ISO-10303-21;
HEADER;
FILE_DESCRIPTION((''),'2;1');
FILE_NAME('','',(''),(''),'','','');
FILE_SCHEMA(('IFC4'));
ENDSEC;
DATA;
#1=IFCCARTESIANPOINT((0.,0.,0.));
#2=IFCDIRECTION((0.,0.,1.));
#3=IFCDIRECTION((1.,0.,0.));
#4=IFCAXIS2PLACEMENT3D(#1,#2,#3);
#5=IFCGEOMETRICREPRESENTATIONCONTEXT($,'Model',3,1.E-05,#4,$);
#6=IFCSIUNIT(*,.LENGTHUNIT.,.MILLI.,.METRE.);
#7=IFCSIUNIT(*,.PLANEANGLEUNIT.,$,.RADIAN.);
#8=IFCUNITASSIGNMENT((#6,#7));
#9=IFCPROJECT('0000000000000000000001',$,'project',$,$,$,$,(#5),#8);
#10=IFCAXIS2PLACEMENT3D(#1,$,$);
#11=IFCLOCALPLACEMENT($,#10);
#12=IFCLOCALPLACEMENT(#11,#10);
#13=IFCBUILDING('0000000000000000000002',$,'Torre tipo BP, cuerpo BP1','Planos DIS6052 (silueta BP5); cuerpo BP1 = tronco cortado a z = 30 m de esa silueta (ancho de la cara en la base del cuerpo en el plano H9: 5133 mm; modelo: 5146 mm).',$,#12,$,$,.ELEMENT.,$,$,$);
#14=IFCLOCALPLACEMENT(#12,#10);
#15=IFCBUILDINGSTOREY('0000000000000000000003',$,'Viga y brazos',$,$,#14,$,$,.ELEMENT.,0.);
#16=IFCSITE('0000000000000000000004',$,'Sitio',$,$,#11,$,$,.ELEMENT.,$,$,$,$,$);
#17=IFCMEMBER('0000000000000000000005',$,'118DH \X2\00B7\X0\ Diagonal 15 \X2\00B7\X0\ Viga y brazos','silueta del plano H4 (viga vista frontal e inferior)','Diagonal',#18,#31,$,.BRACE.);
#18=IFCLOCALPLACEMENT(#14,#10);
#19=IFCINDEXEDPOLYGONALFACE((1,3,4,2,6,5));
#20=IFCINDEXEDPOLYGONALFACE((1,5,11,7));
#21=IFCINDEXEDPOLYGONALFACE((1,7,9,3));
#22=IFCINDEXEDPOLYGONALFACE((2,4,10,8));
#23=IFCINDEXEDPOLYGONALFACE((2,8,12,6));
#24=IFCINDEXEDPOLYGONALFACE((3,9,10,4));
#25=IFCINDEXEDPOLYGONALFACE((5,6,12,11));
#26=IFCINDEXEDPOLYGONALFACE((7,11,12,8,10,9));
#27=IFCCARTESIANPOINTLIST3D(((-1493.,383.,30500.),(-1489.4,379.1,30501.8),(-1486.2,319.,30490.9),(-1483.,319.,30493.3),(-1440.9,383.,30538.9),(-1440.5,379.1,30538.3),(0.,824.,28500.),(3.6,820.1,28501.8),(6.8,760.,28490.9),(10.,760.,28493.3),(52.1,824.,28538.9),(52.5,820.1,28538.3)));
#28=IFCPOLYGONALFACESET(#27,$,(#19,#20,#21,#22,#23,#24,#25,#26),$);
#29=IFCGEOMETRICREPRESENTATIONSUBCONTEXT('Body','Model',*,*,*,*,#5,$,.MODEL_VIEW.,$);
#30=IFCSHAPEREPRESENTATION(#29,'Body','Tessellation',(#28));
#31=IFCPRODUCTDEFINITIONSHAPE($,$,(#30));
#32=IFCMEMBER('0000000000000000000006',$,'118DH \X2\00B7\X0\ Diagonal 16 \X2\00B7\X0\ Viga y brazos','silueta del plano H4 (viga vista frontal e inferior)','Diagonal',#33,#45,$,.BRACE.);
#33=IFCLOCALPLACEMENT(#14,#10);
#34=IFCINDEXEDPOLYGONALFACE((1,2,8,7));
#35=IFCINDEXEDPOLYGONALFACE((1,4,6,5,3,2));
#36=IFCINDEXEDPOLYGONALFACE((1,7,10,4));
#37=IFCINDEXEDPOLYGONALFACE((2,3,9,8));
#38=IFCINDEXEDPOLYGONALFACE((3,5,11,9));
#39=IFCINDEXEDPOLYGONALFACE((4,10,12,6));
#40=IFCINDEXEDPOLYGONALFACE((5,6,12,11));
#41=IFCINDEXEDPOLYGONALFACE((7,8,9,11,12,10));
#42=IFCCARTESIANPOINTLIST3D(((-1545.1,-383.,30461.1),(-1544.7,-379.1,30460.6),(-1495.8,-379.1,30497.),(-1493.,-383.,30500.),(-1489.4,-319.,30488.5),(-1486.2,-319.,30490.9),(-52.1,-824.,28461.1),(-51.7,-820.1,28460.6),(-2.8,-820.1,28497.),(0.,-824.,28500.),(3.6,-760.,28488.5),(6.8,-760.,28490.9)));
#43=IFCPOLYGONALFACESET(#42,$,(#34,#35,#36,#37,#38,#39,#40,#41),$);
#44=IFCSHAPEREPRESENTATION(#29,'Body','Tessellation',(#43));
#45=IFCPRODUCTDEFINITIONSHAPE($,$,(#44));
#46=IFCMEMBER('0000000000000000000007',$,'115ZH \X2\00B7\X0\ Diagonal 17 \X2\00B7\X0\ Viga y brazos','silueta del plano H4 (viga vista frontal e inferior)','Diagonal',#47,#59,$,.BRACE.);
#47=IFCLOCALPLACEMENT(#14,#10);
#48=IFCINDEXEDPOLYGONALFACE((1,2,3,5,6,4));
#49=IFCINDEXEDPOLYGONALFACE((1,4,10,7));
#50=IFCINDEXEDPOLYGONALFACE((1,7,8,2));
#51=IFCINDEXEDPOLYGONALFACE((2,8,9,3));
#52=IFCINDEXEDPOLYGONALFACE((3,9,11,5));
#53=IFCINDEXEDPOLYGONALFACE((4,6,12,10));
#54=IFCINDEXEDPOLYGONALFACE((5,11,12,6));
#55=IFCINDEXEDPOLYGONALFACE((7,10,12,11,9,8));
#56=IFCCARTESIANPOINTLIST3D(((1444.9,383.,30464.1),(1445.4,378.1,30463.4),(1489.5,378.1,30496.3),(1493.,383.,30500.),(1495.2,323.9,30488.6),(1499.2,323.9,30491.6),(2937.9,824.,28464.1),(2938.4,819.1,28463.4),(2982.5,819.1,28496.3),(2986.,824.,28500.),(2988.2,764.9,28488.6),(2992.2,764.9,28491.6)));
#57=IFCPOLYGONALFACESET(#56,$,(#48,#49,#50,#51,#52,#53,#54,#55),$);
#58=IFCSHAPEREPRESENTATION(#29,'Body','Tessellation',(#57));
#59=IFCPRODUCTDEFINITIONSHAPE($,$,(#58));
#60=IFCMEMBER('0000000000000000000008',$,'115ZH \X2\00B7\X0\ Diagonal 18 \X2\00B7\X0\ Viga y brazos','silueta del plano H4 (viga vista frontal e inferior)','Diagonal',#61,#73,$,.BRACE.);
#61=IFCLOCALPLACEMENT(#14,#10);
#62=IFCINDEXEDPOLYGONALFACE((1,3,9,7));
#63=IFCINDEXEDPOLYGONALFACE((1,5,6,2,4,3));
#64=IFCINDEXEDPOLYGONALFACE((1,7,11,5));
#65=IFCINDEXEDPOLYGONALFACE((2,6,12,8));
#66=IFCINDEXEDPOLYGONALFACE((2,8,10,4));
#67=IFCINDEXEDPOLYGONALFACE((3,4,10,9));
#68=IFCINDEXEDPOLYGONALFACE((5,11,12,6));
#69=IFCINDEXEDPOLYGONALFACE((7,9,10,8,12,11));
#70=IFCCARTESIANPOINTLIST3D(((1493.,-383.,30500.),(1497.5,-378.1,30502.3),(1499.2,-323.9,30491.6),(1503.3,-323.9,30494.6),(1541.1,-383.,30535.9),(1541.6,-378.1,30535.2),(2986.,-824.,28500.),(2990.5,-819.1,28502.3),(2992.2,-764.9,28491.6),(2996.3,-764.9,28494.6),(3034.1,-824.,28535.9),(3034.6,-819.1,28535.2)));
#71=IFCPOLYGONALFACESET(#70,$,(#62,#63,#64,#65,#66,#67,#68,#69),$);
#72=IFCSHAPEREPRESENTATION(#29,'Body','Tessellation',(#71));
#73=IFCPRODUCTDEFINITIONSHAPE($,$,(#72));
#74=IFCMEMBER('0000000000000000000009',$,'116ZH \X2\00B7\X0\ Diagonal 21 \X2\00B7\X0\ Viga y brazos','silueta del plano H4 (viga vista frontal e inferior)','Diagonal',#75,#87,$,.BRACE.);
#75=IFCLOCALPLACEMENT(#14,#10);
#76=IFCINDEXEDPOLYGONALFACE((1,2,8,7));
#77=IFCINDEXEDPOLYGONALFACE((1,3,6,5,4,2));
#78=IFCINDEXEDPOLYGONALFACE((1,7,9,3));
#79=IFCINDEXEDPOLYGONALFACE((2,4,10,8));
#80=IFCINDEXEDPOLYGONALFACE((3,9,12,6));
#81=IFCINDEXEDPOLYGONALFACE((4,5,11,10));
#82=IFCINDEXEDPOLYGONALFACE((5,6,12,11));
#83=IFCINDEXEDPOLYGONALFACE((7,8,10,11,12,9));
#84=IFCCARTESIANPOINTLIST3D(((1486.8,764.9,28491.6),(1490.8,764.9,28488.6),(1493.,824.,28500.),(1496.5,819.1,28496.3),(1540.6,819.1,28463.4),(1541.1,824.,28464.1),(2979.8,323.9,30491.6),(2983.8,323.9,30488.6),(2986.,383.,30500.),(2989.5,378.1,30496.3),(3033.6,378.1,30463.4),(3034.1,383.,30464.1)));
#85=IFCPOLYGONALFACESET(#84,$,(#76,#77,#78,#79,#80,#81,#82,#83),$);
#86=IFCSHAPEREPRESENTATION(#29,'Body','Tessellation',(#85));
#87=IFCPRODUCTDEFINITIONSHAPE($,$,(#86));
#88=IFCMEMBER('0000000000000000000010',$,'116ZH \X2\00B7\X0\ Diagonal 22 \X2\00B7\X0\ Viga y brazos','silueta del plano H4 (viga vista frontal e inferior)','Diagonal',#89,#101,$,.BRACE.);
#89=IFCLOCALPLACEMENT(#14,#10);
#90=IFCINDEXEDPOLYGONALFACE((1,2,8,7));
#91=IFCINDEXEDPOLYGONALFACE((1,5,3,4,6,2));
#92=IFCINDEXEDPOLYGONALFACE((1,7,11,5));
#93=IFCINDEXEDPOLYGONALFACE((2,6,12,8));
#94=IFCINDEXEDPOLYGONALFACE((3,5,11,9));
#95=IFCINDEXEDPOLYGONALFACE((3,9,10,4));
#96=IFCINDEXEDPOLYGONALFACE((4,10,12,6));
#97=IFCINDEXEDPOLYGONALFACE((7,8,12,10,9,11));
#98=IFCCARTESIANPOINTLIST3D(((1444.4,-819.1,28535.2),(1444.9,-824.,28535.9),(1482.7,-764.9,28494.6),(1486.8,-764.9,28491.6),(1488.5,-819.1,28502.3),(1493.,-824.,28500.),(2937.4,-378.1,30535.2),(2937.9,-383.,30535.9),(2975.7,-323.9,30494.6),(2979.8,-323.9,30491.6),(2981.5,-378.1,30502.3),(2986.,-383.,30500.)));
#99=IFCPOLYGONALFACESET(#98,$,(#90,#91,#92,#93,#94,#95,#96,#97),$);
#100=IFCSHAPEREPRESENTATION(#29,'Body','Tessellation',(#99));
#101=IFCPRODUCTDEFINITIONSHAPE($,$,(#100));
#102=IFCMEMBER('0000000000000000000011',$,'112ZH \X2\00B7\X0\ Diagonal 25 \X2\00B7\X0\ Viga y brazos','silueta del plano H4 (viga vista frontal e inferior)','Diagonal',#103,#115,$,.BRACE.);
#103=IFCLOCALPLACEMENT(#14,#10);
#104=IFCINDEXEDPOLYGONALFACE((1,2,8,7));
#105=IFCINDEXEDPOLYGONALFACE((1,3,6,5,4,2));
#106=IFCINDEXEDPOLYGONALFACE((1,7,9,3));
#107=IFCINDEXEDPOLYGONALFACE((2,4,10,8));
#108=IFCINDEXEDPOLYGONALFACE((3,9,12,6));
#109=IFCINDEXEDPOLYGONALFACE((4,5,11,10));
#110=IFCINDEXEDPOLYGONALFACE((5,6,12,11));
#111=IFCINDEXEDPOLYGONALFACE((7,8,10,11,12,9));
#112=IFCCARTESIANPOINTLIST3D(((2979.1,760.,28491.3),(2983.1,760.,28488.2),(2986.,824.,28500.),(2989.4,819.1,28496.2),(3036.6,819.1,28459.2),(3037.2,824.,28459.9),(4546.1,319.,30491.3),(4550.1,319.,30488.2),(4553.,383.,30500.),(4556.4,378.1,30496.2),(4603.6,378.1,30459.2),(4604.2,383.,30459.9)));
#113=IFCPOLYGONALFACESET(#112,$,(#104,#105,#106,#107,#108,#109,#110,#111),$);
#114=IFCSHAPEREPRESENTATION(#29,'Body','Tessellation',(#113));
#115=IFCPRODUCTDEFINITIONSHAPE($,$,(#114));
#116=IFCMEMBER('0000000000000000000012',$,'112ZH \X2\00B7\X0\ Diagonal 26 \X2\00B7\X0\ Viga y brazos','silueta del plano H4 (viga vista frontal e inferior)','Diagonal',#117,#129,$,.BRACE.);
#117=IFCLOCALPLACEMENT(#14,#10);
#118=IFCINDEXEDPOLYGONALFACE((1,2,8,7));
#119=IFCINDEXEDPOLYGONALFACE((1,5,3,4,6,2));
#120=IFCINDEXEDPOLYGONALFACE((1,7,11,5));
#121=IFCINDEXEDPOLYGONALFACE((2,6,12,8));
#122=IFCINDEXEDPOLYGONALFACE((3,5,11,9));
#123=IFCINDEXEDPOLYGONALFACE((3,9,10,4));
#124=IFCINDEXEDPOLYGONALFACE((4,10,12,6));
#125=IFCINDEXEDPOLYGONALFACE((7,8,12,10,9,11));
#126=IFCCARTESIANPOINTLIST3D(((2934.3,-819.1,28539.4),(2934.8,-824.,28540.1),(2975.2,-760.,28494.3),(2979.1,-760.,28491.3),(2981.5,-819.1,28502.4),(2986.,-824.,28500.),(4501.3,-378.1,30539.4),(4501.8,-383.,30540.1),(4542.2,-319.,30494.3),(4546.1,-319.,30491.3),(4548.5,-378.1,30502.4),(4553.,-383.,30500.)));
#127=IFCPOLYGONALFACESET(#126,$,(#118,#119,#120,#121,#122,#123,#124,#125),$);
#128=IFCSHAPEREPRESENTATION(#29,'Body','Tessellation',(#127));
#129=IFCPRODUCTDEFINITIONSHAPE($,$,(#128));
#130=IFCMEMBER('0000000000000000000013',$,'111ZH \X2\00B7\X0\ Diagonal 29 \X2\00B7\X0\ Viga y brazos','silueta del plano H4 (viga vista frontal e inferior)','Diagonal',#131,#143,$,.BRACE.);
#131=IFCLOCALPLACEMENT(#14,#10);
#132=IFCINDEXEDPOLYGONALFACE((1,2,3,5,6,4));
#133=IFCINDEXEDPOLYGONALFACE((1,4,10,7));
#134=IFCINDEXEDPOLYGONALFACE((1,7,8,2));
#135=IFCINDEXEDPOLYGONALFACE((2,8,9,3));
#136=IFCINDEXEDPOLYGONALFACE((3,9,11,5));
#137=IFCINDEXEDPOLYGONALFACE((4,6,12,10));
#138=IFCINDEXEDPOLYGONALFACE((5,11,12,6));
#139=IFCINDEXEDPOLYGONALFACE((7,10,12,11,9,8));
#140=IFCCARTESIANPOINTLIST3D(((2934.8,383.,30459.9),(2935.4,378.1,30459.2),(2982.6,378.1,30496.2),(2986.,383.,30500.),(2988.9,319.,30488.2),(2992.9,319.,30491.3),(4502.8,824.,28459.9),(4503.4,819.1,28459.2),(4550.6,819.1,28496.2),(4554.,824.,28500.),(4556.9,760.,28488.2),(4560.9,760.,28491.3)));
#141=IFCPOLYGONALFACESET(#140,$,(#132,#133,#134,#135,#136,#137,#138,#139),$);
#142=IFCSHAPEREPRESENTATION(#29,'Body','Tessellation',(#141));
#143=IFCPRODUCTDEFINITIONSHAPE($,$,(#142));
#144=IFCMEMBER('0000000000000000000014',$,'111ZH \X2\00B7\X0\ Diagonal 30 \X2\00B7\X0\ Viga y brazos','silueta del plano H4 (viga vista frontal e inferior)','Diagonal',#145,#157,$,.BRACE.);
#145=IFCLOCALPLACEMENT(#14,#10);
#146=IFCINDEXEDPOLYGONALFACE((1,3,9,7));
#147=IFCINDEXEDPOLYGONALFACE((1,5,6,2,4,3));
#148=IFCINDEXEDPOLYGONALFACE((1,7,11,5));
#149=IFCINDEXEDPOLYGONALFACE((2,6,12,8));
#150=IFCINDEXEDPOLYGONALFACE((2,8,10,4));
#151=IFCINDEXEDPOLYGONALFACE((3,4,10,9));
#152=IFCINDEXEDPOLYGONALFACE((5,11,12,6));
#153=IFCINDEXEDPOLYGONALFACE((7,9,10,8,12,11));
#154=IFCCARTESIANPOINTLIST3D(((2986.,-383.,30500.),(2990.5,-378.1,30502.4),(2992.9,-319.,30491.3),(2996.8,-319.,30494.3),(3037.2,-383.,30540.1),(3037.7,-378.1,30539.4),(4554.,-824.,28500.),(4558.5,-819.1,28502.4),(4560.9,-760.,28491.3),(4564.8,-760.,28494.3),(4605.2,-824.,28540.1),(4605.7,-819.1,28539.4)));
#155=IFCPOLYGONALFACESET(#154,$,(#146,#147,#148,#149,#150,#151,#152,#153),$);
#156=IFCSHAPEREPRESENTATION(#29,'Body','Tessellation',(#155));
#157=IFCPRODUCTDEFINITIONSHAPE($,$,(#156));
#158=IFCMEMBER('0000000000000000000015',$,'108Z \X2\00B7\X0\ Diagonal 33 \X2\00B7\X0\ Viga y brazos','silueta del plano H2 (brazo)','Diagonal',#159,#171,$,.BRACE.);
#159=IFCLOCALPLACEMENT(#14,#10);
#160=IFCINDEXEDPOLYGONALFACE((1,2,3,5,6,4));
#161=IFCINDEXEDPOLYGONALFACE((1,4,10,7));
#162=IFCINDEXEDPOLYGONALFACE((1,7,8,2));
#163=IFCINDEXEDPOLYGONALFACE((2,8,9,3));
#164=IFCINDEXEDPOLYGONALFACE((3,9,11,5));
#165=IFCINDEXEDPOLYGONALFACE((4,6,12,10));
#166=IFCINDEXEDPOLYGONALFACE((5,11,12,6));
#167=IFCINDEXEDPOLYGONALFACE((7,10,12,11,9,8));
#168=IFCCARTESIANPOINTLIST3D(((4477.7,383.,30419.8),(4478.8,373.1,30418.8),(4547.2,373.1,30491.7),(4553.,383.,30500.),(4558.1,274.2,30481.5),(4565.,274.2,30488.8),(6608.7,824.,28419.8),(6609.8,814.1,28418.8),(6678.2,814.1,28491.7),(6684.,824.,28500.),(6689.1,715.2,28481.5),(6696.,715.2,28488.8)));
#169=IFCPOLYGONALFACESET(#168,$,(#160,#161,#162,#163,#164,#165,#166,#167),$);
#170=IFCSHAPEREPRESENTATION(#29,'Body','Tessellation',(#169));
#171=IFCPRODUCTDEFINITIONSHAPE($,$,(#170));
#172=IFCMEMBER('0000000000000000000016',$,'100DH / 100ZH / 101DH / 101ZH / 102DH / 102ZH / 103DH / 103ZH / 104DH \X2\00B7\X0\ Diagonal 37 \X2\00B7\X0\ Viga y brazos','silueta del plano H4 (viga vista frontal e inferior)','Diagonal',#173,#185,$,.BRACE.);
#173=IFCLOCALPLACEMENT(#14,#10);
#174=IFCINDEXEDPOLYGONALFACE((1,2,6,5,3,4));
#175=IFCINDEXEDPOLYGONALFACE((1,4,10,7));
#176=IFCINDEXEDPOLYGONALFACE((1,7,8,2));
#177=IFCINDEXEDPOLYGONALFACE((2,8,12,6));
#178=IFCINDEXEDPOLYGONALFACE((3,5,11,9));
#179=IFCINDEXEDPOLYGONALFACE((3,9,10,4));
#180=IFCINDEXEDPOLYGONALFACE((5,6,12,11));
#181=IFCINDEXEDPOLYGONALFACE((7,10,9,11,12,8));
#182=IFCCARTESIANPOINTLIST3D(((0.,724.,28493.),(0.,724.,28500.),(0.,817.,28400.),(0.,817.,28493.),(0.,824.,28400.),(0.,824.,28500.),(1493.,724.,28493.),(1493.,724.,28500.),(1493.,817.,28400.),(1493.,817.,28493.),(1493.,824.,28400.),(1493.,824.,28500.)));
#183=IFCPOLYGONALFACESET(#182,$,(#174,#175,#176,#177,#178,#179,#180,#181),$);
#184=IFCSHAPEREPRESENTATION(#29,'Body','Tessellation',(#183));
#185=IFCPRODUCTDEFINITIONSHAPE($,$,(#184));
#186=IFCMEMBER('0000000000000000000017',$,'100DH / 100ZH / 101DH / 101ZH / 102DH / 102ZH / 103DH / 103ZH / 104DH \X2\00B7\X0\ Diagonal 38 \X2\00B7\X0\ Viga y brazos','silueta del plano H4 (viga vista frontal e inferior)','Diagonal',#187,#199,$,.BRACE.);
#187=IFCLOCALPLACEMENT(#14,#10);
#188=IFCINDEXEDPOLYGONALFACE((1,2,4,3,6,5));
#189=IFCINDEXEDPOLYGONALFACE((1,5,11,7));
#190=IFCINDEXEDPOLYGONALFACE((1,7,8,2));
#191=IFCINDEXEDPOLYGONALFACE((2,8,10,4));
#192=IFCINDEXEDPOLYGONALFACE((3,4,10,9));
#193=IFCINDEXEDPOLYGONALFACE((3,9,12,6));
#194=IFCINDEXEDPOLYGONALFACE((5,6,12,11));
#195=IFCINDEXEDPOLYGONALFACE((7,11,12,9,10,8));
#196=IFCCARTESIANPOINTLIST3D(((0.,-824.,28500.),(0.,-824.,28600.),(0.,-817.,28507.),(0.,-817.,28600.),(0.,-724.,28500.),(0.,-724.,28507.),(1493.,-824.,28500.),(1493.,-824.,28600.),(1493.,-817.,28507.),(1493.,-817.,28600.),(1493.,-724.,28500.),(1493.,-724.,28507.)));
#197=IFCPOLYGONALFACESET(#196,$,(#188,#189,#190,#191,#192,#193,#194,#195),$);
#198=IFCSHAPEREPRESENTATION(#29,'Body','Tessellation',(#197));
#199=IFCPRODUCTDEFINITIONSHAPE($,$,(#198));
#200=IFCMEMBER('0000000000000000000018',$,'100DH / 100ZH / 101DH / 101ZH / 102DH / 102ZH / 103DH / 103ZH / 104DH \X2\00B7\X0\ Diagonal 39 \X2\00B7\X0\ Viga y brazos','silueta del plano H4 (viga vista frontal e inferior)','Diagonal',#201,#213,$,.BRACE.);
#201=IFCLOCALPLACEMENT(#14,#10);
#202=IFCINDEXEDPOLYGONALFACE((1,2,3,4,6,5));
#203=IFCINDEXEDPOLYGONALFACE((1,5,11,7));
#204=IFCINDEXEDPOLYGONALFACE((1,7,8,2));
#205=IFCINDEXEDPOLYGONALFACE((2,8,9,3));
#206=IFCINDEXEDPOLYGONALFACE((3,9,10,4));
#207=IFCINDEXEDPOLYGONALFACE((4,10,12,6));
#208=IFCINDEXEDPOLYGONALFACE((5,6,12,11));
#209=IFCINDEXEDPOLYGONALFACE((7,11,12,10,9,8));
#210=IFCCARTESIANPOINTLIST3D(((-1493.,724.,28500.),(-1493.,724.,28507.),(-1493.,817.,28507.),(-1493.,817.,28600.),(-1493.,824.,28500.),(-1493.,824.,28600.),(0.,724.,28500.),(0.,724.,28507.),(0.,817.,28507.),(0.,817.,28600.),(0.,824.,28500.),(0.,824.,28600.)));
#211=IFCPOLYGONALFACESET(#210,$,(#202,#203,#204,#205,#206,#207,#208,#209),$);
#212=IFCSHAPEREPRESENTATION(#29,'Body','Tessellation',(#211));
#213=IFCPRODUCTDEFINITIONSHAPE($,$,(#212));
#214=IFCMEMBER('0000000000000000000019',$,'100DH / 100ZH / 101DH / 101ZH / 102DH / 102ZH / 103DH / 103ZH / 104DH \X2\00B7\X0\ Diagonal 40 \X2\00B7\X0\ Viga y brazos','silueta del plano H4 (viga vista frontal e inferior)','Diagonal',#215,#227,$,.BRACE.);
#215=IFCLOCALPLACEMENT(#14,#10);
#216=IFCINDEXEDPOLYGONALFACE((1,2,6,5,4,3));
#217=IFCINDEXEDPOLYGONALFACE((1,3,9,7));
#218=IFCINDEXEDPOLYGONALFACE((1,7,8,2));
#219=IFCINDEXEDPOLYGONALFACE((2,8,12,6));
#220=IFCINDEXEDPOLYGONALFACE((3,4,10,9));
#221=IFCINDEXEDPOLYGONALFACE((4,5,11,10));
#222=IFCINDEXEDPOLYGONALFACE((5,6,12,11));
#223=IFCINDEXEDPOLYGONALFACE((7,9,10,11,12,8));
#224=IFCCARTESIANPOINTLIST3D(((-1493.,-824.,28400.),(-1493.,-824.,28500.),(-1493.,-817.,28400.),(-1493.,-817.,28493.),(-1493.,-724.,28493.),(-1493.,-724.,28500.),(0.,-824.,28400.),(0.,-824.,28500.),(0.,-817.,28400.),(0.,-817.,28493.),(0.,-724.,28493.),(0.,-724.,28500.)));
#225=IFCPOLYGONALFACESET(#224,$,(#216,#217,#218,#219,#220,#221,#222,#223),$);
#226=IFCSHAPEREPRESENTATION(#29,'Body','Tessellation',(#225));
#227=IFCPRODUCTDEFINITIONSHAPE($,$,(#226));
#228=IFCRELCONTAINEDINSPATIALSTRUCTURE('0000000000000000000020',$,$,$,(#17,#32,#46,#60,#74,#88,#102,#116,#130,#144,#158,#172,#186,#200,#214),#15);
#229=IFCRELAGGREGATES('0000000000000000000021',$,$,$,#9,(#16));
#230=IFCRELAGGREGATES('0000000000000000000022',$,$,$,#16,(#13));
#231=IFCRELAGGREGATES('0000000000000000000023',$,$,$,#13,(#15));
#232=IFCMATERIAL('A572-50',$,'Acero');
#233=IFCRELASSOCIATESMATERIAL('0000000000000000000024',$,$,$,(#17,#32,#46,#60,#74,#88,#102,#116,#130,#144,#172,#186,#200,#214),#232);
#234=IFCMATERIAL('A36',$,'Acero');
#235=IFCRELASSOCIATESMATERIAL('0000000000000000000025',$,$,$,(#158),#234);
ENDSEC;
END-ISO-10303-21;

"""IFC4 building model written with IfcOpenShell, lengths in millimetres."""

from ifc_helpers import new_model, si_unit, frame, frame_2d, origin, origin_with_axes, place, context, subcontext, project, spatial, l_section, extrude, material, element, save


model = new_model("IFC4")

# Units and contexts
model_context = context("Model", 3, precision=1e-05, world=origin_with_axes())
body_context = subcontext(model_context, "Body", "Model", "MODEL_VIEW")
ifc_project = project(units=[si_unit("LENGTHUNIT", "METRE", prefix="MILLI"), si_unit("PLANEANGLEUNIT", "RADIAN")], contexts=[model_context])

# Site, building, storey
site_placement = place(None, origin())
site = spatial("IfcSite", under=ifc_project, at=site_placement, Name="Sitio", CompositionType="ELEMENT")
building_placement = place(site_placement, origin())
building = spatial("IfcBuilding", under=site, at=building_placement, Name="Torre tipo BP, cuerpo BP1", Description="Planos DIS6052 (silueta BP5); cuerpo BP1 = tronco cortado a z = 30 m de esa silueta (ancho de la cara en la base del cuerpo en el plano H9: 5133 mm; modelo: 5146 mm).", CompositionType="ELEMENT")
storey_placement = place(building_placement, origin())
storey = spatial("IfcBuildingStorey", under=building, at=storey_placement, Name="Viga y brazos", CompositionType="ELEMENT", Elevation=0.0)

# Members
ifc_material_1 = material(Name="A572-50", Category="Acero")
for number, where, z_axis, x_axis, name in (
    (1, (0.0, 824.0, 28500.0), (-0.589078, -0.174001, 0.78912), (0.104088, -0.984745, -0.139435), "118DH · Diagonal 15 · Viga y brazos"),
    (2, (0.0, -824.0, 28500.0), (-0.589078, 0.174001, 0.78912), (0.104088, 0.984745, -0.139435), "118DH · Diagonal 16 · Viga y brazos"),
):
    element("IfcMember", number, at=place(storey_placement, frame(where, z_axis=z_axis, x_axis=x_axis)), inside=storey, material=ifc_material_1, Name=name, Description="silueta del plano H4 (viga vista frontal e inferior)", ObjectType="Diagonal", PredefinedType="BRACE", context=body_context, shape_type="SweptSolid", body=[
        extrude(l_section(Depth=65.0, Width=65.0, Thickness=4.0, at=frame_2d((32.5, 32.5))), None, (0.0, 0.0, 1.0), 2534.5),
    ])
for number, where, z_axis, x_axis, name in (
    (3, (1493.0, 383.0, 30500.0), (0.589078, 0.174001, -0.78912), (0.104088, -0.984745, -0.139435), "115ZH · Diagonal 17 · Viga y brazos"),
    (4, (1493.0, -383.0, 30500.0), (0.589078, -0.174001, -0.78912), (0.104088, 0.984745, -0.139435), "115ZH · Diagonal 18 · Viga y brazos"),
    (5, (1493.0, 824.0, 28500.0), (0.589078, -0.174001, 0.78912), (-0.104088, -0.984745, -0.139435), "116ZH · Diagonal 21 · Viga y brazos"),
    (6, (1493.0, -824.0, 28500.0), (0.589078, 0.174001, 0.78912), (-0.104088, 0.984745, -0.139435), "116ZH · Diagonal 22 · Viga y brazos"),
):
    element("IfcMember", number, at=place(storey_placement, frame(where, z_axis=z_axis, x_axis=x_axis)), inside=storey, material=ifc_material_1, Name=name, Description="silueta del plano H4 (viga vista frontal e inferior)", ObjectType="Diagonal", PredefinedType="BRACE", context=body_context, shape_type="SweptSolid", body=[
        extrude(l_section(Depth=60.0, Width=60.0, Thickness=5.0, at=frame_2d((30.0, 30.0))), None, (0.0, 0.0, 1.0), 2534.5),
    ])
for number, where, z_axis, x_axis, name in (
    (7, (2986.0, 824.0, 28500.0), (0.607658, -0.171013, 0.775568), (-0.105471, -0.985269, -0.134615), "112ZH · Diagonal 25 · Viga y brazos"),
    (8, (2986.0, -824.0, 28500.0), (0.607658, 0.171013, 0.775568), (-0.105471, 0.985269, -0.134615), "112ZH · Diagonal 26 · Viga y brazos"),
):
    element("IfcMember", number, at=place(storey_placement, frame(where, z_axis=z_axis, x_axis=x_axis)), inside=storey, material=ifc_material_1, Name=name, Description="silueta del plano H4 (viga vista frontal e inferior)", ObjectType="Diagonal", PredefinedType="BRACE", context=body_context, shape_type="SweptSolid", body=[
        extrude(l_section(Depth=65.0, Width=65.0, Thickness=5.0, at=frame_2d((32.5, 32.5))), None, (0.0, 0.0, 1.0), 2578.8),
    ])
for number, where, z_axis, x_axis, name in (
    (9, (2986.0, 383.0, 30500.0), (0.607902, 0.170973, -0.775386), (0.105488, -0.985276, -0.134551), "111ZH · Diagonal 29 · Viga y brazos"),
    (10, (2986.0, -383.0, 30500.0), (0.607902, -0.170973, -0.775386), (0.105488, 0.985276, -0.134551), "111ZH · Diagonal 30 · Viga y brazos"),
):
    element("IfcMember", number, at=place(storey_placement, frame(where, z_axis=z_axis, x_axis=x_axis)), inside=storey, material=ifc_material_1, Name=name, Description="silueta del plano H4 (viga vista frontal e inferior)", ObjectType="Diagonal", PredefinedType="BRACE", context=body_context, shape_type="SweptSolid", body=[
        extrude(l_section(Depth=65.0, Width=65.0, Thickness=5.0, at=frame_2d((32.5, 32.5))), None, (0.0, 0.0, 1.0), 2579.4),
    ])
ifc_material_2 = material(Name="A36", Category="Acero")
member_placement = place(storey_placement, frame((4553.0, 383.0, 30500.0), z_axis=(0.721001, 0.149208, -0.676679), x_axis=(0.108797, -0.988806, -0.102109)))
element("IfcMember", 11, at=member_placement, inside=storey, material=ifc_material_2, Name="108Z · Diagonal 33 · Viga y brazos", Description="silueta del plano H2 (brazo)", ObjectType="Diagonal", PredefinedType="BRACE", context=body_context, shape_type="SweptSolid", body=[
    extrude(l_section(Depth=110.0, Width=110.0, Thickness=10.0, at=frame_2d((55.0, 55.0))), None, (0.0, 0.0, 1.0), 2955.6),
])
for number, where, z_axis, x_axis, name in (
    (12, (0.0, 824.0, 28500.0), (1.0, 0.0, 0.0), (0.0, -1.0, 0.0), "100DH / 100ZH / 101DH / 101ZH / 102DH / 102ZH / 103DH / 103ZH / 104DH · Diagonal 37 · Viga y brazos"),
    (13, (0.0, -824.0, 28500.0), (1.0, 0.0, 0.0), (0.0, 1.0, 0.0), "100DH / 100ZH / 101DH / 101ZH / 102DH / 102ZH / 103DH / 103ZH / 104DH · Diagonal 38 · Viga y brazos"),
    (14, (0.0, 824.0, 28500.0), (-1.0, 0.0, 0.0), (0.0, -1.0, 0.0), "100DH / 100ZH / 101DH / 101ZH / 102DH / 102ZH / 103DH / 103ZH / 104DH · Diagonal 39 · Viga y brazos"),
    (15, (0.0, -824.0, 28500.0), (-1.0, 0.0, 0.0), (0.0, 1.0, 0.0), "100DH / 100ZH / 101DH / 101ZH / 102DH / 102ZH / 103DH / 103ZH / 104DH · Diagonal 40 · Viga y brazos"),
):
    element("IfcMember", number, at=place(storey_placement, frame(where, z_axis=z_axis, x_axis=x_axis)), inside=storey, material=ifc_material_1, Name=name, Description="silueta del plano H4 (viga vista frontal e inferior)", ObjectType="Diagonal", PredefinedType="BRACE", context=body_context, shape_type="SweptSolid", body=[
        extrude(l_section(Depth=100.0, Width=100.0, Thickness=7.0, at=frame_2d((50.0, 50.0))), None, (0.0, 0.0, 1.0), 1493.0),
    ])

save(model, "model.ifc")
